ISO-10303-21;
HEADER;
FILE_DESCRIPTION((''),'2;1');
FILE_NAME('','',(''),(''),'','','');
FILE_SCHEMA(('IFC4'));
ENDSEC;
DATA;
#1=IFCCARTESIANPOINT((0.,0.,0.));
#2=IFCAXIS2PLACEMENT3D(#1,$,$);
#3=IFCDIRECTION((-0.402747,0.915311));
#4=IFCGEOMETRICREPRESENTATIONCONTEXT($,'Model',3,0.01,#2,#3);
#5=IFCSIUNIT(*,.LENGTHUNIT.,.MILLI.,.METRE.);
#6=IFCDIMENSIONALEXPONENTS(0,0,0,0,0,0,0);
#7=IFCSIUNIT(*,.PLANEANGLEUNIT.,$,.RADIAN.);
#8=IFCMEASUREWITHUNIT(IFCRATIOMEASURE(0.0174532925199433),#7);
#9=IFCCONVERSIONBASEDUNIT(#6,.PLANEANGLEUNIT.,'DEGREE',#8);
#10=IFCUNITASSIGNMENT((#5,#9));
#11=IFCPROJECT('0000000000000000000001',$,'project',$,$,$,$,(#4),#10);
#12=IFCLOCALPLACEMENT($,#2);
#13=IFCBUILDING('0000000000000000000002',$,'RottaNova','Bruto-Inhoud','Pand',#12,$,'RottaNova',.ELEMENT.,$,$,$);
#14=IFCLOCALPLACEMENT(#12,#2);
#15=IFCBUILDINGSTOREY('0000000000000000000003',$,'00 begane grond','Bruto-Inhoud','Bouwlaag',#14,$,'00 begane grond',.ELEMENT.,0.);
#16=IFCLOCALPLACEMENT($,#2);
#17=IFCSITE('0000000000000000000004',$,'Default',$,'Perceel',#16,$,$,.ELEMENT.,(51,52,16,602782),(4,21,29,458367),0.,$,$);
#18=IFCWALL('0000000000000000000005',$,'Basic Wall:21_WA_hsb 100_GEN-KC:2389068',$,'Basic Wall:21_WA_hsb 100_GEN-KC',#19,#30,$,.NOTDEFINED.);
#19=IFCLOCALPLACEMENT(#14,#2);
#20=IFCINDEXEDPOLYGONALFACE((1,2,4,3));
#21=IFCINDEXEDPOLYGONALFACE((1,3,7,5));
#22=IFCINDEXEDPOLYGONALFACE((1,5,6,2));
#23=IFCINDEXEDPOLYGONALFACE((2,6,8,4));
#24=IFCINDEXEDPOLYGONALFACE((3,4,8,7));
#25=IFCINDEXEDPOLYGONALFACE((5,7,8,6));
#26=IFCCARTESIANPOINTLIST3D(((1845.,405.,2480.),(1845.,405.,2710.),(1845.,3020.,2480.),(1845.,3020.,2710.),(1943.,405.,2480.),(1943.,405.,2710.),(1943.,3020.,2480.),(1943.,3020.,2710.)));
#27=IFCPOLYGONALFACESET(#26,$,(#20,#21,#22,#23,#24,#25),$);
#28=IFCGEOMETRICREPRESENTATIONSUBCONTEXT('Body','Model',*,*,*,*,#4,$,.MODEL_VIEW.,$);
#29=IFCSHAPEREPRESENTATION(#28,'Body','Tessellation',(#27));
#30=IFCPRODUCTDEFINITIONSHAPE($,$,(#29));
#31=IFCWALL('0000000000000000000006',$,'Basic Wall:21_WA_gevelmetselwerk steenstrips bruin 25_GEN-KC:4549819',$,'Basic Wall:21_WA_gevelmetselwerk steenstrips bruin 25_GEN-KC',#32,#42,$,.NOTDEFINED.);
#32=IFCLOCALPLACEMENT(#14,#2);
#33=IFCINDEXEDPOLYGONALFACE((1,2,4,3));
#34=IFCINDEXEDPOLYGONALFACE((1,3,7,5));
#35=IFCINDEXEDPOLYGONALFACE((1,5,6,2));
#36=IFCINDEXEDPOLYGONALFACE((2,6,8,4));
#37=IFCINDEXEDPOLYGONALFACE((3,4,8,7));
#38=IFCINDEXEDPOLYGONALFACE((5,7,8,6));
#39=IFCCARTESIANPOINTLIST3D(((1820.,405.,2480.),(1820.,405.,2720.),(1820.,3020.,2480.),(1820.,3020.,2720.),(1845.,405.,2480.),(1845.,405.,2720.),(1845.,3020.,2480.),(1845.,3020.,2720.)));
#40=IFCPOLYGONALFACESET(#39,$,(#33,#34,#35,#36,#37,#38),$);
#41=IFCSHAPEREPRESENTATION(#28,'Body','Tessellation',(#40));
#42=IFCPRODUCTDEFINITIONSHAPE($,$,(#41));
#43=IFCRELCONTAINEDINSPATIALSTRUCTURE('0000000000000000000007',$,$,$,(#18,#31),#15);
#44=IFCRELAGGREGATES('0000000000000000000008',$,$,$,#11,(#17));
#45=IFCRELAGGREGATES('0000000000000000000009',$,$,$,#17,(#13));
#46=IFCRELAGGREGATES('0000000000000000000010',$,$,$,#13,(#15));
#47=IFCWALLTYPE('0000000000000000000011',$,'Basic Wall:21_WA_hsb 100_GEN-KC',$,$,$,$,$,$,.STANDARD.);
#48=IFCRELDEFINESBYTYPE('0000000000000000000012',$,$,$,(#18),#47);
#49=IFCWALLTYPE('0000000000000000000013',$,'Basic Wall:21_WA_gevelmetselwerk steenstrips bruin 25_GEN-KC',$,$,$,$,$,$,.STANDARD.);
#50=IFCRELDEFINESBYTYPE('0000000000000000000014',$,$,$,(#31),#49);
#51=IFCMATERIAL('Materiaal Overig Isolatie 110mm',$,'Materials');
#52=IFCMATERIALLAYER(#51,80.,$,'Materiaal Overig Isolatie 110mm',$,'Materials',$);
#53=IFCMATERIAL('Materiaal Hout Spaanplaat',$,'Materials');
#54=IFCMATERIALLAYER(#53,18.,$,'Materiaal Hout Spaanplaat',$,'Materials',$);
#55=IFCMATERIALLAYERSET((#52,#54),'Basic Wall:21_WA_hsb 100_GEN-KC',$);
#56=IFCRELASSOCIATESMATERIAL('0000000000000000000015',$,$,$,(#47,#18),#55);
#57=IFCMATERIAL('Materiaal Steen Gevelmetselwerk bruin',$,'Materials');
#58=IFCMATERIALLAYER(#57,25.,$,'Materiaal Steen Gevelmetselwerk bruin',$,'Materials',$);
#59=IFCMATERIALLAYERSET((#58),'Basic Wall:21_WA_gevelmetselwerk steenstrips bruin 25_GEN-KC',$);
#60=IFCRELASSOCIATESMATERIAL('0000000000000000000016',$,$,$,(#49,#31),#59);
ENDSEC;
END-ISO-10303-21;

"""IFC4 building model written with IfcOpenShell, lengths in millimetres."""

from ifc_helpers import new_model, entity, si_unit, converted_unit, direction, frame, frame_2d, origin, place, context, subcontext, project, spatial, rectangle, extrude, material, layer, layer_set, type_object, element, save


model = new_model("IFC4")

# Units and contexts
model_context = context("Model", 3, precision=0.01, world=origin(), true_north=direction((-0.402747, 0.915311)))
body_context = subcontext(model_context, "Body", "Model", "MODEL_VIEW")
ifc_project = project(units=[si_unit("LENGTHUNIT", "METRE", prefix="MILLI"), converted_unit("PLANEANGLEUNIT", "DEGREE", entity("IfcRatioMeasure", 0.0174532925199433), si_unit("PLANEANGLEUNIT", "RADIAN"), dimensions=[0, 0, 0, 0, 0, 0, 0])], contexts=[model_context])

# Site, building, storey
site_placement = place(None, origin())
site = spatial("IfcSite", under=ifc_project, at=site_placement, Name="Default", ObjectType="Perceel", CompositionType="ELEMENT", RefLatitude=(51, 52, 16, 602782), RefLongitude=(4, 21, 29, 458367), RefElevation=0.0)
building_placement = place(None, origin())
building = spatial("IfcBuilding", under=site, at=building_placement, Name="RottaNova", Description="Bruto-Inhoud", ObjectType="Pand", LongName="RottaNova", CompositionType="ELEMENT")
storey_placement = place(building_placement, origin())
storey = spatial("IfcBuildingStorey", under=building, at=storey_placement, Name="00 begane grond", Description="Bruto-Inhoud", ObjectType="Bouwlaag", LongName="00 begane grond", CompositionType="ELEMENT", Elevation=0.0)

# Walls
ifc_material_1 = material(Name="Materiaal Steen Gevelmetselwerk bruin", Category="Materials")
ifc_material_2 = material(Name="Materiaal Overig Isolatie 110mm", Category="Materials")
ifc_layer_1 = layer(ifc_material_2, 80.0, Name="Materiaal Overig Isolatie 110mm", Category="Materials")
ifc_material_3 = material(Name="Materiaal Hout Spaanplaat", Category="Materials")
ifc_layer_2 = layer(ifc_material_3, 18.0, Name="Materiaal Hout Spaanplaat", Category="Materials")
ifc_layer_set_1 = layer_set([ifc_layer_1, ifc_layer_2], Name="Basic Wall:21_WA_hsb 100_GEN-KC")
wall_type_1 = type_object("IfcWallType", Name="Basic Wall:21_WA_hsb 100_GEN-KC", PredefinedType="STANDARD", material=ifc_layer_set_1)
wall_1_placement = place(storey_placement, frame((1894.0, 3020.0, 2480.0), z_axis=(0.0, 0.0, 1.0), x_axis=(0.0, -1.0, 0.0)))
element("IfcWall", 1, at=wall_1_placement, inside=storey, type_object=wall_type_1, material=ifc_layer_set_1, Name="Basic Wall:21_WA_hsb 100_GEN-KC:2389068", ObjectType="Basic Wall:21_WA_hsb 100_GEN-KC", PredefinedType="NOTDEFINED", context=body_context, shape_type="SweptSolid", body=[
    extrude(rectangle(XDim=2615.0, YDim=98.0, at=frame_2d((1307.5, 0.0), x_axis=(-1.0, 0.0))), origin(), (0.0, 0.0, 1.0), 230.0),
])
ifc_layer_3 = layer(ifc_material_1, 25.0, Name="Materiaal Steen Gevelmetselwerk bruin", Category="Materials")
ifc_layer_set_2 = layer_set([ifc_layer_3], Name="Basic Wall:21_WA_gevelmetselwerk steenstrips bruin 25_GEN-KC")
wall_type_2 = type_object("IfcWallType", Name="Basic Wall:21_WA_gevelmetselwerk steenstrips bruin 25_GEN-KC", PredefinedType="STANDARD", material=ifc_layer_set_2)
wall_2_placement = place(storey_placement, frame((1832.5, 405.0, 2480.0), z_axis=(0.0, 0.0, 1.0), x_axis=(0.0, 1.0, 0.0)))
element("IfcWall", 2, at=wall_2_placement, inside=storey, type_object=wall_type_2, material=ifc_layer_set_2, Name="Basic Wall:21_WA_gevelmetselwerk steenstrips bruin 25_GEN-KC:4549819", ObjectType="Basic Wall:21_WA_gevelmetselwerk steenstrips bruin 25_GEN-KC", PredefinedType="NOTDEFINED", context=body_context, shape_type="SweptSolid", body=[
    extrude(rectangle(XDim=2615.0, YDim=25.0, at=frame_2d((1307.5, 0.0), x_axis=(-1.0, 0.0))), origin(), (0.0, 0.0, 1.0), 240.0),
])

save(model, "model.ifc")
